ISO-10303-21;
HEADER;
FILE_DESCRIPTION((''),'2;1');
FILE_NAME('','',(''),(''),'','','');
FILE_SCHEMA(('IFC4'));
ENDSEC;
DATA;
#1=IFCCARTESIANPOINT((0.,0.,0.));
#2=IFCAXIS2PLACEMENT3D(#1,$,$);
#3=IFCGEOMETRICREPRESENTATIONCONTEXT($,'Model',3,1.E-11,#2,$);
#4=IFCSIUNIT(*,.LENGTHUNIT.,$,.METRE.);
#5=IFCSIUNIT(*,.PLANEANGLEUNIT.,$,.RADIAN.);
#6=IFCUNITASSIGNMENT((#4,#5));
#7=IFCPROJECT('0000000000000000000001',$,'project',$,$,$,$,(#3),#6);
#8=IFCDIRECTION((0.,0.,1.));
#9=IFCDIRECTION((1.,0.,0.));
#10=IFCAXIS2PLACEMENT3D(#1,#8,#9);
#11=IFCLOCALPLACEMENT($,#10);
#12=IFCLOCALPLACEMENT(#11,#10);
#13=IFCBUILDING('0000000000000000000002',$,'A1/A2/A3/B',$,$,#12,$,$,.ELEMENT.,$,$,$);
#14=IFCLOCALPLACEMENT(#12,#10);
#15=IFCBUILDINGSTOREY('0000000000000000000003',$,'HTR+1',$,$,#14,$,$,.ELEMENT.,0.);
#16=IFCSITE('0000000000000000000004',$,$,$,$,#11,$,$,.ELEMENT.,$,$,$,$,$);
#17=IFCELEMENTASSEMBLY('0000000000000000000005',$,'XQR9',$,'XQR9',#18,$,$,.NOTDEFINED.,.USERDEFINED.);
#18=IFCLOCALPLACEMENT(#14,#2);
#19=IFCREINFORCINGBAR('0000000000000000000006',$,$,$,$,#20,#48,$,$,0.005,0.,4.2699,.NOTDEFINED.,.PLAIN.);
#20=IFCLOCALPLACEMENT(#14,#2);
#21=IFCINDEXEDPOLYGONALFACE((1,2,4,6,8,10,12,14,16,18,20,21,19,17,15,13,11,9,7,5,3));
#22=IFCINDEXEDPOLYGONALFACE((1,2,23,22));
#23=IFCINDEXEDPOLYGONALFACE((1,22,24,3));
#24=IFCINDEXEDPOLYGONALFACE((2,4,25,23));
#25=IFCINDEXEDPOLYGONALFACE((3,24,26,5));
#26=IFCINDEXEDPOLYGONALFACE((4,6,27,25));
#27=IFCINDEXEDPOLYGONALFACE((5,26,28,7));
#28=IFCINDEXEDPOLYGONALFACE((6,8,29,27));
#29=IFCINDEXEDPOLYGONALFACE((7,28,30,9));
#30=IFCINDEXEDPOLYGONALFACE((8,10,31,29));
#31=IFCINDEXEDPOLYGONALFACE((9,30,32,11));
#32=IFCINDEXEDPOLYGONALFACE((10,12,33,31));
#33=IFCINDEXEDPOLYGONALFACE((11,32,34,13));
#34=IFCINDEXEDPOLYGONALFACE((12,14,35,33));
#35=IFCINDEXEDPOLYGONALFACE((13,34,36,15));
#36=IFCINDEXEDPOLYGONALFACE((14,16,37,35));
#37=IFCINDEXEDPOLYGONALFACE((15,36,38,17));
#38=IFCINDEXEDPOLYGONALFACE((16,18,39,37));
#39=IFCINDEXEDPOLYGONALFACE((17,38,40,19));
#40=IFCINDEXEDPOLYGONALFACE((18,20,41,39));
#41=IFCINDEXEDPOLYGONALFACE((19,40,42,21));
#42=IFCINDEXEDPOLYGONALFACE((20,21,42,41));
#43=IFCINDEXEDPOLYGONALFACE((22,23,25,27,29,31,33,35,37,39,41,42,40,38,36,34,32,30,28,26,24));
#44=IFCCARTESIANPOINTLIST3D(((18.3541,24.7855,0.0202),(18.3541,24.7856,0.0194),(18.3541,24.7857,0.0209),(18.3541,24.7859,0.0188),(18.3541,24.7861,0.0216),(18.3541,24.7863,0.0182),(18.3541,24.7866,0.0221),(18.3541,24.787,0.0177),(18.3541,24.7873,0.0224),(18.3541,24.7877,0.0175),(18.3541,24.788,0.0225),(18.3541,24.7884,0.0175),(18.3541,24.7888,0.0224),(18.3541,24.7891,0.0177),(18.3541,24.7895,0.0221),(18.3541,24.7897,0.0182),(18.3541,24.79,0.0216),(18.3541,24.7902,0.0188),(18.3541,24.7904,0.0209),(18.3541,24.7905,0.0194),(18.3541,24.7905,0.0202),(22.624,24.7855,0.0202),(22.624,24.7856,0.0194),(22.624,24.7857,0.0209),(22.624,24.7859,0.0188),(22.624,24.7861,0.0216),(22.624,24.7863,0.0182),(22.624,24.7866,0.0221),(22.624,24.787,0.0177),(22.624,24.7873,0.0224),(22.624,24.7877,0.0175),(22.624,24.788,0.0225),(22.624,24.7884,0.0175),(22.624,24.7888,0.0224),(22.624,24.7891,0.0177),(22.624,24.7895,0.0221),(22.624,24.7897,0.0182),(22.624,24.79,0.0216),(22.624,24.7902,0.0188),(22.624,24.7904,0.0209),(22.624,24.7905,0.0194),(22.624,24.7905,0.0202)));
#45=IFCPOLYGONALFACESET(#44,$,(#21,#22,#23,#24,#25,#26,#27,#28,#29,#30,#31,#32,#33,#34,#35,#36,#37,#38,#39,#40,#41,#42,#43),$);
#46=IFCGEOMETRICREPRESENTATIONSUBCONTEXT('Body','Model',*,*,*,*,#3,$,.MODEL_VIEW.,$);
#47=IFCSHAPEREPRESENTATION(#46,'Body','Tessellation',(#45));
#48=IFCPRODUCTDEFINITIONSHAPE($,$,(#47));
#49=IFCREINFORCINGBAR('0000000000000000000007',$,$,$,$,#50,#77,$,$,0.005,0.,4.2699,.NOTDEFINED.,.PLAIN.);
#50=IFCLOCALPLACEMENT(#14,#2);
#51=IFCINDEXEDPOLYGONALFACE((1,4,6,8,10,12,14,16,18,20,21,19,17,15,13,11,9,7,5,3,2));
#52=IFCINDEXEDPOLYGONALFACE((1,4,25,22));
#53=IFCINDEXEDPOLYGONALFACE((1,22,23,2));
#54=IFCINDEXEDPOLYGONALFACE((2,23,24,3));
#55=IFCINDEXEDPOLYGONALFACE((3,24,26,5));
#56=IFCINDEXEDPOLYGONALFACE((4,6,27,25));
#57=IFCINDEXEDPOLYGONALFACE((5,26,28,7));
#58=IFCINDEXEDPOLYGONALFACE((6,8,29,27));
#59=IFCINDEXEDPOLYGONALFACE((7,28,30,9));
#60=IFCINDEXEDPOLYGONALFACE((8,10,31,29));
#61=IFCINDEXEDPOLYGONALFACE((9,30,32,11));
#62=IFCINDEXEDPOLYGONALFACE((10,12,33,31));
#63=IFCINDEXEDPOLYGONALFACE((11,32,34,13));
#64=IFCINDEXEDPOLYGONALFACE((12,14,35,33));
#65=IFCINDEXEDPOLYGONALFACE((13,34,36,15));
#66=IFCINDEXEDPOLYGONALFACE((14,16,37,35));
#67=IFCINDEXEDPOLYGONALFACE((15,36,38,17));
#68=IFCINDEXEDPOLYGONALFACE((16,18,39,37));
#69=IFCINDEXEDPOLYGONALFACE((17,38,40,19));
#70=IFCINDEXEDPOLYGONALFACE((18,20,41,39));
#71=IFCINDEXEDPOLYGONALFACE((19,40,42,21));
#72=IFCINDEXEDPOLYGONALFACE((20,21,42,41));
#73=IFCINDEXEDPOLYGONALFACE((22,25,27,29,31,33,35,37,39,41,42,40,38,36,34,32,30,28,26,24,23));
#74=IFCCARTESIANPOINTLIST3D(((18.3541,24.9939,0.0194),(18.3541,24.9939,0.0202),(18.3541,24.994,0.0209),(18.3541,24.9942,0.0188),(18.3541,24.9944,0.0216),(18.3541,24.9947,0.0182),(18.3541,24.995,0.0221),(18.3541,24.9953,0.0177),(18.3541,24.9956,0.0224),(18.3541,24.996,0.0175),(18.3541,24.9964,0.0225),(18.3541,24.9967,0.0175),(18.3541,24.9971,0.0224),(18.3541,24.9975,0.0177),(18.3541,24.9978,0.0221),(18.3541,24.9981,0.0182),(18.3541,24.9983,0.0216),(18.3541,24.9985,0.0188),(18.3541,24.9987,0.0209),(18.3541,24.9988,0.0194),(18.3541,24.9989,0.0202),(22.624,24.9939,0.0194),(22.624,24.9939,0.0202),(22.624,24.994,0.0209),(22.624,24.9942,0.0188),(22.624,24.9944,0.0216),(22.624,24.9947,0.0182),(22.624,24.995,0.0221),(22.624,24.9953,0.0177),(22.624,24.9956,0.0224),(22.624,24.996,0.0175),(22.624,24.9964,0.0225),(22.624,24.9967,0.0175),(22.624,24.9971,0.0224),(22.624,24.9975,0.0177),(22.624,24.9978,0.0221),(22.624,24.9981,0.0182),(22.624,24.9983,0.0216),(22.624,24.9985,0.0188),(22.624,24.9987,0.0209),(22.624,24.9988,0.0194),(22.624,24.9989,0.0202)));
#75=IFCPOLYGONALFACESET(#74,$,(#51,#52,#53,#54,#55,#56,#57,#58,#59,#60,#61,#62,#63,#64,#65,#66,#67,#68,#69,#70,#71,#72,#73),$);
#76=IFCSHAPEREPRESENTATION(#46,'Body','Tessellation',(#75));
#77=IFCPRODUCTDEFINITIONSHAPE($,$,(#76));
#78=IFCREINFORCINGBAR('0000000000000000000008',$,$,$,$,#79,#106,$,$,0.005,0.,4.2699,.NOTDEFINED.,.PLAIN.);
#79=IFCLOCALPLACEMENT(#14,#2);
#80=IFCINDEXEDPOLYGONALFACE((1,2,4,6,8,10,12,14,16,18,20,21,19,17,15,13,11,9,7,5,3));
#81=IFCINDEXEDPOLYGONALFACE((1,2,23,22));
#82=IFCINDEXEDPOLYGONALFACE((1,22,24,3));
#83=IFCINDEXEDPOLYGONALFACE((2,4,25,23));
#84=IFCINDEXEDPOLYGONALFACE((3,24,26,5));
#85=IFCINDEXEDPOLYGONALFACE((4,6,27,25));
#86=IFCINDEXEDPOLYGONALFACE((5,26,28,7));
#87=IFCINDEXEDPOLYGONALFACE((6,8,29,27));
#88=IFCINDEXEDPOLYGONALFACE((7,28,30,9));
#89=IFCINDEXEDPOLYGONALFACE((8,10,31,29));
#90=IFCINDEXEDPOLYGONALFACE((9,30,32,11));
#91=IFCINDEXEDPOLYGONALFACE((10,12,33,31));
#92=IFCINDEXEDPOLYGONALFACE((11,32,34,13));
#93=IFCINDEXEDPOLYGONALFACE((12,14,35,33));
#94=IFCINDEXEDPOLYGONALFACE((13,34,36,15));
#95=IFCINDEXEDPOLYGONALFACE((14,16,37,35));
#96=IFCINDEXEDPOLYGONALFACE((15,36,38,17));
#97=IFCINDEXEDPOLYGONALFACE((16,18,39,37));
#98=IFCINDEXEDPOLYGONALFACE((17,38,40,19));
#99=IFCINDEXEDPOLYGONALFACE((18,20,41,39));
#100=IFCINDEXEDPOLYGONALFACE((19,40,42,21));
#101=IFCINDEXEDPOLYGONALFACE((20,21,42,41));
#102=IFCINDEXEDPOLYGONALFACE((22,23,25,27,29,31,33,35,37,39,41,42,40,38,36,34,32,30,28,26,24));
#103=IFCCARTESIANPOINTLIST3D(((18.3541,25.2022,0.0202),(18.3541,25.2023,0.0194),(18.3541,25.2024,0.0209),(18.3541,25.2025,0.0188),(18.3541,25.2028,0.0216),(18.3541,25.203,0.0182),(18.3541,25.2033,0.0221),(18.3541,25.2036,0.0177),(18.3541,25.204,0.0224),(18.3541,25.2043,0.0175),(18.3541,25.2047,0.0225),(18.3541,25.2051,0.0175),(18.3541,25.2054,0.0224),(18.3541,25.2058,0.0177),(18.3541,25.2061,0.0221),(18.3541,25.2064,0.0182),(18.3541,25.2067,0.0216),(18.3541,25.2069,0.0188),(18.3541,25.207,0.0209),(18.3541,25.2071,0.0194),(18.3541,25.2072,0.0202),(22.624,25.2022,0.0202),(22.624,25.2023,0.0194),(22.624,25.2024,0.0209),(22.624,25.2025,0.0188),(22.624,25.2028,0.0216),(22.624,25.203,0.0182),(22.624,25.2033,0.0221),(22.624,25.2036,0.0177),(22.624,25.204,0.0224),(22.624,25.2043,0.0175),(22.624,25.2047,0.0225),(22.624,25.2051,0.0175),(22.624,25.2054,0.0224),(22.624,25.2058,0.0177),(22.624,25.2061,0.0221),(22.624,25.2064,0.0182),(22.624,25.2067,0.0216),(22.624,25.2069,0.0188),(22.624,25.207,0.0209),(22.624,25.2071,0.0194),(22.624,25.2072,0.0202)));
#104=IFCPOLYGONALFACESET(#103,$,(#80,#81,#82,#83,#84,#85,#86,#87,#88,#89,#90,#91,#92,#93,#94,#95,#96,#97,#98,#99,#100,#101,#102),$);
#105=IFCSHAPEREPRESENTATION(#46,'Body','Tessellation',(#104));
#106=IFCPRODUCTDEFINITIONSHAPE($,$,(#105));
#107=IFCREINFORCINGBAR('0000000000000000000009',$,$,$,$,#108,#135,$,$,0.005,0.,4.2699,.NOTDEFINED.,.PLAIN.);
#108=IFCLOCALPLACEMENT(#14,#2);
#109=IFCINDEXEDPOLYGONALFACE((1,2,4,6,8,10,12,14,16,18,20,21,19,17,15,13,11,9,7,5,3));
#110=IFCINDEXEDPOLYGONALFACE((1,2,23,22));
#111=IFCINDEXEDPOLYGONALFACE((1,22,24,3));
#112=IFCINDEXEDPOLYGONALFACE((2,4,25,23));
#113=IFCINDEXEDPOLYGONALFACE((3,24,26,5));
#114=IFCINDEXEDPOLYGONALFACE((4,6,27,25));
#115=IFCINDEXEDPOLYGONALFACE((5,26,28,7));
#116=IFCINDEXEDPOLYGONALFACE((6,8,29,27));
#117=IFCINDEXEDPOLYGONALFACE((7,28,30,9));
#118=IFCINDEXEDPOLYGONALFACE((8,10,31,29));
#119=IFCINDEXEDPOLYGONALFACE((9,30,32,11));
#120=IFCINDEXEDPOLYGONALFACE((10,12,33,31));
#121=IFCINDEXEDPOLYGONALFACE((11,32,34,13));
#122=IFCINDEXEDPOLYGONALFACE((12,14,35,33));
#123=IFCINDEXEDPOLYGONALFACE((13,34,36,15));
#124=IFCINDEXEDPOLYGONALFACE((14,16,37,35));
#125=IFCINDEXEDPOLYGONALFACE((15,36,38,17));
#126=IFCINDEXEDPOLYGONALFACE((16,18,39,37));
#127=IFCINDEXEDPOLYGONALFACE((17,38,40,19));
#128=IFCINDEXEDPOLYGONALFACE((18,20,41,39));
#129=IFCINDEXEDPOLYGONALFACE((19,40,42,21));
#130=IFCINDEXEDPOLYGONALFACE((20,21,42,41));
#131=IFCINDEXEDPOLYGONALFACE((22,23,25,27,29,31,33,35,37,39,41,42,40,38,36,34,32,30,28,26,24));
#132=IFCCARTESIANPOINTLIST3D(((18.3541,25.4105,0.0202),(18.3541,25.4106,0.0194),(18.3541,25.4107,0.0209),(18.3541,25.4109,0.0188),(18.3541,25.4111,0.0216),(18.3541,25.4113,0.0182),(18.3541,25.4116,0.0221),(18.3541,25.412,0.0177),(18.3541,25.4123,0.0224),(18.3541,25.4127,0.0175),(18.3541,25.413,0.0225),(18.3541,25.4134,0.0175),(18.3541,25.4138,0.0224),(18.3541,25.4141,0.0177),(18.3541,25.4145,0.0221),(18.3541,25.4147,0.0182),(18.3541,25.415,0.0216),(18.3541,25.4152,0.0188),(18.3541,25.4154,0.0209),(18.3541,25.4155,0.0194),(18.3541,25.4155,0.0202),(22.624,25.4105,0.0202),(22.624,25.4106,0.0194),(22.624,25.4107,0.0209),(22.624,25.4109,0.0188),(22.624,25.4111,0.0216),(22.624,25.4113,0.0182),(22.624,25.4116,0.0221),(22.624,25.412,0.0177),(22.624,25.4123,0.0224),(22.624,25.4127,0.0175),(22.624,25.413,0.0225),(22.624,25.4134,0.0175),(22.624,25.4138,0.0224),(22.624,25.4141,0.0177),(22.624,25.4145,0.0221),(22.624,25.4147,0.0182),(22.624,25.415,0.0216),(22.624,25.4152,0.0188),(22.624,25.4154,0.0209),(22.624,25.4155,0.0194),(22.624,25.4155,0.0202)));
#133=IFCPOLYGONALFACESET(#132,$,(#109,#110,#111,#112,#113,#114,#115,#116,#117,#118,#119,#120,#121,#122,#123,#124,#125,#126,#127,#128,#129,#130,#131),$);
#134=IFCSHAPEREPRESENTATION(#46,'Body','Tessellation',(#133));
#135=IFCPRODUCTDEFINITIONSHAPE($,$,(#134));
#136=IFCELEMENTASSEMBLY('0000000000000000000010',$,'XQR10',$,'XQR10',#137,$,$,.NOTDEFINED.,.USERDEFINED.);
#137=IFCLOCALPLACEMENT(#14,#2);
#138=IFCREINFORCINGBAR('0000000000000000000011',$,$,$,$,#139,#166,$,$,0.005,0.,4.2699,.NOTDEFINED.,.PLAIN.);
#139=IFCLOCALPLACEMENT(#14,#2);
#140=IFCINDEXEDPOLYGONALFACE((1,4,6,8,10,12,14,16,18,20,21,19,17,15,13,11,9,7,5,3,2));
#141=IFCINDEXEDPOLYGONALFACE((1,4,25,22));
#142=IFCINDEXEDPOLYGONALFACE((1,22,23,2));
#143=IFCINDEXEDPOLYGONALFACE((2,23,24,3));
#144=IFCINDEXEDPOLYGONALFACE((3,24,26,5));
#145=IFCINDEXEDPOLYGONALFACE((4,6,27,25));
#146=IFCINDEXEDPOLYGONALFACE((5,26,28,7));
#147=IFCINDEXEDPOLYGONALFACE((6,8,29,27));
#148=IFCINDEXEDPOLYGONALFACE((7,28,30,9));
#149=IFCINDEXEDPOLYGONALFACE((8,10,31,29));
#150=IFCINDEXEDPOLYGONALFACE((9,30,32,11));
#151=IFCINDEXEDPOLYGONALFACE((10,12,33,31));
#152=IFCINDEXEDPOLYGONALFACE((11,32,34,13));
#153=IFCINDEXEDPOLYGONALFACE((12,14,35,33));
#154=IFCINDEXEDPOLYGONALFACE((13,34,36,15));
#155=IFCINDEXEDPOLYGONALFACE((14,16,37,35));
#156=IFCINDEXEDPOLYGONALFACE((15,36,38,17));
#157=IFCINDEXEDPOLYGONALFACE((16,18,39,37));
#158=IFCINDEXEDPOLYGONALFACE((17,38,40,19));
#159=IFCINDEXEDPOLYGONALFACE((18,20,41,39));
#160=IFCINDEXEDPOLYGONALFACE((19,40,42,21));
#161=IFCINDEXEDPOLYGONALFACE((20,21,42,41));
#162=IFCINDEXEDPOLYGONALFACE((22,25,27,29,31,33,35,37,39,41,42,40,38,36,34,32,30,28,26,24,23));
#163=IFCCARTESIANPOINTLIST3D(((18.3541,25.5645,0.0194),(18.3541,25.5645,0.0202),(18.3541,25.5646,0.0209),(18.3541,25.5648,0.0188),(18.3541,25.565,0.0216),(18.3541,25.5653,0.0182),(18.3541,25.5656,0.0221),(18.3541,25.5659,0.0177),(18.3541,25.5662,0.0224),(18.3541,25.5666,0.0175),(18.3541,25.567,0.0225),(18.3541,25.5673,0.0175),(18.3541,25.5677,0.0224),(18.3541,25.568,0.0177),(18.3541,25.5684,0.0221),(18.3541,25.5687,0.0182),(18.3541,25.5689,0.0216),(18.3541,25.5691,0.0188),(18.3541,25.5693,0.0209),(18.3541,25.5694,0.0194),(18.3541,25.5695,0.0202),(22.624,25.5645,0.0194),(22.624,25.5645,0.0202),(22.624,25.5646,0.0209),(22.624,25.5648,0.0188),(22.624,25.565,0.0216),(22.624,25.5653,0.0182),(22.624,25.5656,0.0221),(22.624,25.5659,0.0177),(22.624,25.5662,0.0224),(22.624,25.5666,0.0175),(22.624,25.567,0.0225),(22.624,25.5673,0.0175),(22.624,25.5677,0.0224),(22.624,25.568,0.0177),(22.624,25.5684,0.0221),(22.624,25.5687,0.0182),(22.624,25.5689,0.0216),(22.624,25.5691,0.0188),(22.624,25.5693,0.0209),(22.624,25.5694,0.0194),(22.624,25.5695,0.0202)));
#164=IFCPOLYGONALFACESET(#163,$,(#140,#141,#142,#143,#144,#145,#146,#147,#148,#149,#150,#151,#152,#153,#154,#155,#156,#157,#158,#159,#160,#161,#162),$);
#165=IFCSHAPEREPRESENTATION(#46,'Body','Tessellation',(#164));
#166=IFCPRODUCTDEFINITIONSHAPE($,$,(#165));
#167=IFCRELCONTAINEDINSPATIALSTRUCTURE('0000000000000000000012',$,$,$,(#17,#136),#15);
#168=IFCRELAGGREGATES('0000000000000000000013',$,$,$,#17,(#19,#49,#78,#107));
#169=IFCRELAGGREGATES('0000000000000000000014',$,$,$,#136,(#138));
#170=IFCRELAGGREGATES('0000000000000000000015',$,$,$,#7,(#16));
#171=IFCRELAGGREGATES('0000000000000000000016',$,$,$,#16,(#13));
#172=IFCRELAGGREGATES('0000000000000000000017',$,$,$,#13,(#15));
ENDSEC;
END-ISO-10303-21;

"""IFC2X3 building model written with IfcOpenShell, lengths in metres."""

from ifc_helpers import new_model, entity, si_unit, origin, origin_with_axes, place, context, subcontext, project, spatial, shape, element, aggregate, save


model = new_model("IFC2X3")

# Units and contexts
model_context = context("Model", 3, precision=1e-11, world=origin())
body_context = subcontext(model_context, "Body", "Model", "MODEL_VIEW")
ifc_project = project(units=[si_unit("LENGTHUNIT", "METRE"), si_unit("PLANEANGLEUNIT", "RADIAN")], contexts=[model_context])

# Site, building, storey
site_placement = place(None, origin_with_axes())
site = spatial("IfcSite", under=ifc_project, at=site_placement, CompositionType="ELEMENT")
building_placement = place(site_placement, origin_with_axes())
building = spatial("IfcBuilding", under=site, at=building_placement, Name="A1/A2/A3/B", CompositionType="ELEMENT")
storey_placement = place(building_placement, origin_with_axes())
storey = spatial("IfcBuildingStorey", under=building, at=storey_placement, Name="HTR+1", CompositionType="ELEMENT", Elevation=0.0)

# Element assemblies, reinforcing bars
assembly_1_placement = place(storey_placement, origin_with_axes())
assembly_1 = element("IfcElementAssembly", 1, at=assembly_1_placement, inside=storey, Name="XQR9", ObjectType="XQR9", AssemblyPlace="NOTDEFINED", PredefinedType="USERDEFINED")
reinforcing_bar_1_placement = place(assembly_1_placement, origin_with_axes())
reinforcing_bar_1 = element("IfcReinforcingBar", 2, at=reinforcing_bar_1_placement, BarLength=4.2699, BarRole="NOTDEFINED", BarSurface="PLAIN", CrossSectionArea=0.0, NominalDiameter=0.005, shapes=[
    shape(body_context, "Body", "AdvancedSweptSolid", [entity("IfcSweptDiskSolid", entity("IfcPolyline", [entity("IfcCartesianPoint", [18.3541, 24.788, 0.02]), entity("IfcCartesianPoint", [22.624, 24.788, 0.02])]), 0.0025, None, 0.0, 4.2699)]),
    shape(body_context, "Body", "AdvancedSweptSolid", [entity("IfcSweptDiskSolid", entity("IfcPolyline", [entity("IfcCartesianPoint", [18.3541, 24.788, 0.02]), entity("IfcCartesianPoint", [22.624, 24.788, 0.02])]), 0.0025, None, 0.0, 4.2699)]),
])
reinforcing_bar_2_placement = place(assembly_1_placement, origin_with_axes())
reinforcing_bar_2 = element("IfcReinforcingBar", 3, at=reinforcing_bar_2_placement, BarLength=4.2699, BarRole="NOTDEFINED", BarSurface="PLAIN", CrossSectionArea=0.0, NominalDiameter=0.005, shapes=[
    shape(body_context, "Body", "AdvancedSweptSolid", [entity("IfcSweptDiskSolid", entity("IfcPolyline", [entity("IfcCartesianPoint", [18.3541, 24.9964, 0.02]), entity("IfcCartesianPoint", [22.624, 24.9964, 0.02])]), 0.0025, None, 0.0, 4.2699)]),
    shape(body_context, "Body", "AdvancedSweptSolid", [entity("IfcSweptDiskSolid", entity("IfcPolyline", [entity("IfcCartesianPoint", [18.3541, 24.9964, 0.02]), entity("IfcCartesianPoint", [22.624, 24.9964, 0.02])]), 0.0025, None, 0.0, 4.2699)]),
])
reinforcing_bar_3_placement = place(assembly_1_placement, origin_with_axes())
reinforcing_bar_3 = element("IfcReinforcingBar", 4, at=reinforcing_bar_3_placement, BarLength=4.2699, BarRole="NOTDEFINED", BarSurface="PLAIN", CrossSectionArea=0.0, NominalDiameter=0.005, shapes=[
    shape(body_context, "Body", "AdvancedSweptSolid", [entity("IfcSweptDiskSolid", entity("IfcPolyline", [entity("IfcCartesianPoint", [18.3541, 25.2047, 0.02]), entity("IfcCartesianPoint", [22.624, 25.2047, 0.02])]), 0.0025, None, 0.0, 4.2699)]),
    shape(body_context, "Body", "AdvancedSweptSolid", [entity("IfcSweptDiskSolid", entity("IfcPolyline", [entity("IfcCartesianPoint", [18.3541, 25.2047, 0.02]), entity("IfcCartesianPoint", [22.624, 25.2047, 0.02])]), 0.0025, None, 0.0, 4.2699)]),
])
reinforcing_bar_4_placement = place(assembly_1_placement, origin_with_axes())
reinforcing_bar_4 = element("IfcReinforcingBar", 5, at=reinforcing_bar_4_placement, BarLength=4.2699, BarRole="NOTDEFINED", BarSurface="PLAIN", CrossSectionArea=0.0, NominalDiameter=0.005, shapes=[
    shape(body_context, "Body", "AdvancedSweptSolid", [entity("IfcSweptDiskSolid", entity("IfcPolyline", [entity("IfcCartesianPoint", [18.3541, 25.413, 0.02]), entity("IfcCartesianPoint", [22.624, 25.413, 0.02])]), 0.0025, None, 0.0, 4.2699)]),
    shape(body_context, "Body", "AdvancedSweptSolid", [entity("IfcSweptDiskSolid", entity("IfcPolyline", [entity("IfcCartesianPoint", [18.3541, 25.413, 0.02]), entity("IfcCartesianPoint", [22.624, 25.413, 0.02])]), 0.0025, None, 0.0, 4.2699)]),
])
aggregate(assembly_1, [reinforcing_bar_1, reinforcing_bar_2, reinforcing_bar_3, reinforcing_bar_4])
assembly_2_placement = place(storey_placement, origin_with_axes())
assembly_2 = element("IfcElementAssembly", 6, at=assembly_2_placement, inside=storey, Name="XQR10", ObjectType="XQR10", AssemblyPlace="NOTDEFINED", PredefinedType="USERDEFINED")
reinforcing_bar_5_placement = place(assembly_2_placement, origin_with_axes())
reinforcing_bar_5 = element("IfcReinforcingBar", 7, at=reinforcing_bar_5_placement, BarLength=4.2699, BarRole="NOTDEFINED", BarSurface="PLAIN", CrossSectionArea=0.0, NominalDiameter=0.005, shapes=[
    shape(body_context, "Body", "AdvancedSweptSolid", [entity("IfcSweptDiskSolid", entity("IfcPolyline", [entity("IfcCartesianPoint", [18.3541, 25.567, 0.02]), entity("IfcCartesianPoint", [22.624, 25.567, 0.02])]), 0.0025, None, 0.0, 4.2699)]),
    shape(body_context, "Body", "AdvancedSweptSolid", [entity("IfcSweptDiskSolid", entity("IfcPolyline", [entity("IfcCartesianPoint", [18.3541, 25.567, 0.02]), entity("IfcCartesianPoint", [22.624, 25.567, 0.02])]), 0.0025, None, 0.0, 4.2699)]),
])
aggregate(assembly_2, [reinforcing_bar_5])

save(model, "model.ifc")
